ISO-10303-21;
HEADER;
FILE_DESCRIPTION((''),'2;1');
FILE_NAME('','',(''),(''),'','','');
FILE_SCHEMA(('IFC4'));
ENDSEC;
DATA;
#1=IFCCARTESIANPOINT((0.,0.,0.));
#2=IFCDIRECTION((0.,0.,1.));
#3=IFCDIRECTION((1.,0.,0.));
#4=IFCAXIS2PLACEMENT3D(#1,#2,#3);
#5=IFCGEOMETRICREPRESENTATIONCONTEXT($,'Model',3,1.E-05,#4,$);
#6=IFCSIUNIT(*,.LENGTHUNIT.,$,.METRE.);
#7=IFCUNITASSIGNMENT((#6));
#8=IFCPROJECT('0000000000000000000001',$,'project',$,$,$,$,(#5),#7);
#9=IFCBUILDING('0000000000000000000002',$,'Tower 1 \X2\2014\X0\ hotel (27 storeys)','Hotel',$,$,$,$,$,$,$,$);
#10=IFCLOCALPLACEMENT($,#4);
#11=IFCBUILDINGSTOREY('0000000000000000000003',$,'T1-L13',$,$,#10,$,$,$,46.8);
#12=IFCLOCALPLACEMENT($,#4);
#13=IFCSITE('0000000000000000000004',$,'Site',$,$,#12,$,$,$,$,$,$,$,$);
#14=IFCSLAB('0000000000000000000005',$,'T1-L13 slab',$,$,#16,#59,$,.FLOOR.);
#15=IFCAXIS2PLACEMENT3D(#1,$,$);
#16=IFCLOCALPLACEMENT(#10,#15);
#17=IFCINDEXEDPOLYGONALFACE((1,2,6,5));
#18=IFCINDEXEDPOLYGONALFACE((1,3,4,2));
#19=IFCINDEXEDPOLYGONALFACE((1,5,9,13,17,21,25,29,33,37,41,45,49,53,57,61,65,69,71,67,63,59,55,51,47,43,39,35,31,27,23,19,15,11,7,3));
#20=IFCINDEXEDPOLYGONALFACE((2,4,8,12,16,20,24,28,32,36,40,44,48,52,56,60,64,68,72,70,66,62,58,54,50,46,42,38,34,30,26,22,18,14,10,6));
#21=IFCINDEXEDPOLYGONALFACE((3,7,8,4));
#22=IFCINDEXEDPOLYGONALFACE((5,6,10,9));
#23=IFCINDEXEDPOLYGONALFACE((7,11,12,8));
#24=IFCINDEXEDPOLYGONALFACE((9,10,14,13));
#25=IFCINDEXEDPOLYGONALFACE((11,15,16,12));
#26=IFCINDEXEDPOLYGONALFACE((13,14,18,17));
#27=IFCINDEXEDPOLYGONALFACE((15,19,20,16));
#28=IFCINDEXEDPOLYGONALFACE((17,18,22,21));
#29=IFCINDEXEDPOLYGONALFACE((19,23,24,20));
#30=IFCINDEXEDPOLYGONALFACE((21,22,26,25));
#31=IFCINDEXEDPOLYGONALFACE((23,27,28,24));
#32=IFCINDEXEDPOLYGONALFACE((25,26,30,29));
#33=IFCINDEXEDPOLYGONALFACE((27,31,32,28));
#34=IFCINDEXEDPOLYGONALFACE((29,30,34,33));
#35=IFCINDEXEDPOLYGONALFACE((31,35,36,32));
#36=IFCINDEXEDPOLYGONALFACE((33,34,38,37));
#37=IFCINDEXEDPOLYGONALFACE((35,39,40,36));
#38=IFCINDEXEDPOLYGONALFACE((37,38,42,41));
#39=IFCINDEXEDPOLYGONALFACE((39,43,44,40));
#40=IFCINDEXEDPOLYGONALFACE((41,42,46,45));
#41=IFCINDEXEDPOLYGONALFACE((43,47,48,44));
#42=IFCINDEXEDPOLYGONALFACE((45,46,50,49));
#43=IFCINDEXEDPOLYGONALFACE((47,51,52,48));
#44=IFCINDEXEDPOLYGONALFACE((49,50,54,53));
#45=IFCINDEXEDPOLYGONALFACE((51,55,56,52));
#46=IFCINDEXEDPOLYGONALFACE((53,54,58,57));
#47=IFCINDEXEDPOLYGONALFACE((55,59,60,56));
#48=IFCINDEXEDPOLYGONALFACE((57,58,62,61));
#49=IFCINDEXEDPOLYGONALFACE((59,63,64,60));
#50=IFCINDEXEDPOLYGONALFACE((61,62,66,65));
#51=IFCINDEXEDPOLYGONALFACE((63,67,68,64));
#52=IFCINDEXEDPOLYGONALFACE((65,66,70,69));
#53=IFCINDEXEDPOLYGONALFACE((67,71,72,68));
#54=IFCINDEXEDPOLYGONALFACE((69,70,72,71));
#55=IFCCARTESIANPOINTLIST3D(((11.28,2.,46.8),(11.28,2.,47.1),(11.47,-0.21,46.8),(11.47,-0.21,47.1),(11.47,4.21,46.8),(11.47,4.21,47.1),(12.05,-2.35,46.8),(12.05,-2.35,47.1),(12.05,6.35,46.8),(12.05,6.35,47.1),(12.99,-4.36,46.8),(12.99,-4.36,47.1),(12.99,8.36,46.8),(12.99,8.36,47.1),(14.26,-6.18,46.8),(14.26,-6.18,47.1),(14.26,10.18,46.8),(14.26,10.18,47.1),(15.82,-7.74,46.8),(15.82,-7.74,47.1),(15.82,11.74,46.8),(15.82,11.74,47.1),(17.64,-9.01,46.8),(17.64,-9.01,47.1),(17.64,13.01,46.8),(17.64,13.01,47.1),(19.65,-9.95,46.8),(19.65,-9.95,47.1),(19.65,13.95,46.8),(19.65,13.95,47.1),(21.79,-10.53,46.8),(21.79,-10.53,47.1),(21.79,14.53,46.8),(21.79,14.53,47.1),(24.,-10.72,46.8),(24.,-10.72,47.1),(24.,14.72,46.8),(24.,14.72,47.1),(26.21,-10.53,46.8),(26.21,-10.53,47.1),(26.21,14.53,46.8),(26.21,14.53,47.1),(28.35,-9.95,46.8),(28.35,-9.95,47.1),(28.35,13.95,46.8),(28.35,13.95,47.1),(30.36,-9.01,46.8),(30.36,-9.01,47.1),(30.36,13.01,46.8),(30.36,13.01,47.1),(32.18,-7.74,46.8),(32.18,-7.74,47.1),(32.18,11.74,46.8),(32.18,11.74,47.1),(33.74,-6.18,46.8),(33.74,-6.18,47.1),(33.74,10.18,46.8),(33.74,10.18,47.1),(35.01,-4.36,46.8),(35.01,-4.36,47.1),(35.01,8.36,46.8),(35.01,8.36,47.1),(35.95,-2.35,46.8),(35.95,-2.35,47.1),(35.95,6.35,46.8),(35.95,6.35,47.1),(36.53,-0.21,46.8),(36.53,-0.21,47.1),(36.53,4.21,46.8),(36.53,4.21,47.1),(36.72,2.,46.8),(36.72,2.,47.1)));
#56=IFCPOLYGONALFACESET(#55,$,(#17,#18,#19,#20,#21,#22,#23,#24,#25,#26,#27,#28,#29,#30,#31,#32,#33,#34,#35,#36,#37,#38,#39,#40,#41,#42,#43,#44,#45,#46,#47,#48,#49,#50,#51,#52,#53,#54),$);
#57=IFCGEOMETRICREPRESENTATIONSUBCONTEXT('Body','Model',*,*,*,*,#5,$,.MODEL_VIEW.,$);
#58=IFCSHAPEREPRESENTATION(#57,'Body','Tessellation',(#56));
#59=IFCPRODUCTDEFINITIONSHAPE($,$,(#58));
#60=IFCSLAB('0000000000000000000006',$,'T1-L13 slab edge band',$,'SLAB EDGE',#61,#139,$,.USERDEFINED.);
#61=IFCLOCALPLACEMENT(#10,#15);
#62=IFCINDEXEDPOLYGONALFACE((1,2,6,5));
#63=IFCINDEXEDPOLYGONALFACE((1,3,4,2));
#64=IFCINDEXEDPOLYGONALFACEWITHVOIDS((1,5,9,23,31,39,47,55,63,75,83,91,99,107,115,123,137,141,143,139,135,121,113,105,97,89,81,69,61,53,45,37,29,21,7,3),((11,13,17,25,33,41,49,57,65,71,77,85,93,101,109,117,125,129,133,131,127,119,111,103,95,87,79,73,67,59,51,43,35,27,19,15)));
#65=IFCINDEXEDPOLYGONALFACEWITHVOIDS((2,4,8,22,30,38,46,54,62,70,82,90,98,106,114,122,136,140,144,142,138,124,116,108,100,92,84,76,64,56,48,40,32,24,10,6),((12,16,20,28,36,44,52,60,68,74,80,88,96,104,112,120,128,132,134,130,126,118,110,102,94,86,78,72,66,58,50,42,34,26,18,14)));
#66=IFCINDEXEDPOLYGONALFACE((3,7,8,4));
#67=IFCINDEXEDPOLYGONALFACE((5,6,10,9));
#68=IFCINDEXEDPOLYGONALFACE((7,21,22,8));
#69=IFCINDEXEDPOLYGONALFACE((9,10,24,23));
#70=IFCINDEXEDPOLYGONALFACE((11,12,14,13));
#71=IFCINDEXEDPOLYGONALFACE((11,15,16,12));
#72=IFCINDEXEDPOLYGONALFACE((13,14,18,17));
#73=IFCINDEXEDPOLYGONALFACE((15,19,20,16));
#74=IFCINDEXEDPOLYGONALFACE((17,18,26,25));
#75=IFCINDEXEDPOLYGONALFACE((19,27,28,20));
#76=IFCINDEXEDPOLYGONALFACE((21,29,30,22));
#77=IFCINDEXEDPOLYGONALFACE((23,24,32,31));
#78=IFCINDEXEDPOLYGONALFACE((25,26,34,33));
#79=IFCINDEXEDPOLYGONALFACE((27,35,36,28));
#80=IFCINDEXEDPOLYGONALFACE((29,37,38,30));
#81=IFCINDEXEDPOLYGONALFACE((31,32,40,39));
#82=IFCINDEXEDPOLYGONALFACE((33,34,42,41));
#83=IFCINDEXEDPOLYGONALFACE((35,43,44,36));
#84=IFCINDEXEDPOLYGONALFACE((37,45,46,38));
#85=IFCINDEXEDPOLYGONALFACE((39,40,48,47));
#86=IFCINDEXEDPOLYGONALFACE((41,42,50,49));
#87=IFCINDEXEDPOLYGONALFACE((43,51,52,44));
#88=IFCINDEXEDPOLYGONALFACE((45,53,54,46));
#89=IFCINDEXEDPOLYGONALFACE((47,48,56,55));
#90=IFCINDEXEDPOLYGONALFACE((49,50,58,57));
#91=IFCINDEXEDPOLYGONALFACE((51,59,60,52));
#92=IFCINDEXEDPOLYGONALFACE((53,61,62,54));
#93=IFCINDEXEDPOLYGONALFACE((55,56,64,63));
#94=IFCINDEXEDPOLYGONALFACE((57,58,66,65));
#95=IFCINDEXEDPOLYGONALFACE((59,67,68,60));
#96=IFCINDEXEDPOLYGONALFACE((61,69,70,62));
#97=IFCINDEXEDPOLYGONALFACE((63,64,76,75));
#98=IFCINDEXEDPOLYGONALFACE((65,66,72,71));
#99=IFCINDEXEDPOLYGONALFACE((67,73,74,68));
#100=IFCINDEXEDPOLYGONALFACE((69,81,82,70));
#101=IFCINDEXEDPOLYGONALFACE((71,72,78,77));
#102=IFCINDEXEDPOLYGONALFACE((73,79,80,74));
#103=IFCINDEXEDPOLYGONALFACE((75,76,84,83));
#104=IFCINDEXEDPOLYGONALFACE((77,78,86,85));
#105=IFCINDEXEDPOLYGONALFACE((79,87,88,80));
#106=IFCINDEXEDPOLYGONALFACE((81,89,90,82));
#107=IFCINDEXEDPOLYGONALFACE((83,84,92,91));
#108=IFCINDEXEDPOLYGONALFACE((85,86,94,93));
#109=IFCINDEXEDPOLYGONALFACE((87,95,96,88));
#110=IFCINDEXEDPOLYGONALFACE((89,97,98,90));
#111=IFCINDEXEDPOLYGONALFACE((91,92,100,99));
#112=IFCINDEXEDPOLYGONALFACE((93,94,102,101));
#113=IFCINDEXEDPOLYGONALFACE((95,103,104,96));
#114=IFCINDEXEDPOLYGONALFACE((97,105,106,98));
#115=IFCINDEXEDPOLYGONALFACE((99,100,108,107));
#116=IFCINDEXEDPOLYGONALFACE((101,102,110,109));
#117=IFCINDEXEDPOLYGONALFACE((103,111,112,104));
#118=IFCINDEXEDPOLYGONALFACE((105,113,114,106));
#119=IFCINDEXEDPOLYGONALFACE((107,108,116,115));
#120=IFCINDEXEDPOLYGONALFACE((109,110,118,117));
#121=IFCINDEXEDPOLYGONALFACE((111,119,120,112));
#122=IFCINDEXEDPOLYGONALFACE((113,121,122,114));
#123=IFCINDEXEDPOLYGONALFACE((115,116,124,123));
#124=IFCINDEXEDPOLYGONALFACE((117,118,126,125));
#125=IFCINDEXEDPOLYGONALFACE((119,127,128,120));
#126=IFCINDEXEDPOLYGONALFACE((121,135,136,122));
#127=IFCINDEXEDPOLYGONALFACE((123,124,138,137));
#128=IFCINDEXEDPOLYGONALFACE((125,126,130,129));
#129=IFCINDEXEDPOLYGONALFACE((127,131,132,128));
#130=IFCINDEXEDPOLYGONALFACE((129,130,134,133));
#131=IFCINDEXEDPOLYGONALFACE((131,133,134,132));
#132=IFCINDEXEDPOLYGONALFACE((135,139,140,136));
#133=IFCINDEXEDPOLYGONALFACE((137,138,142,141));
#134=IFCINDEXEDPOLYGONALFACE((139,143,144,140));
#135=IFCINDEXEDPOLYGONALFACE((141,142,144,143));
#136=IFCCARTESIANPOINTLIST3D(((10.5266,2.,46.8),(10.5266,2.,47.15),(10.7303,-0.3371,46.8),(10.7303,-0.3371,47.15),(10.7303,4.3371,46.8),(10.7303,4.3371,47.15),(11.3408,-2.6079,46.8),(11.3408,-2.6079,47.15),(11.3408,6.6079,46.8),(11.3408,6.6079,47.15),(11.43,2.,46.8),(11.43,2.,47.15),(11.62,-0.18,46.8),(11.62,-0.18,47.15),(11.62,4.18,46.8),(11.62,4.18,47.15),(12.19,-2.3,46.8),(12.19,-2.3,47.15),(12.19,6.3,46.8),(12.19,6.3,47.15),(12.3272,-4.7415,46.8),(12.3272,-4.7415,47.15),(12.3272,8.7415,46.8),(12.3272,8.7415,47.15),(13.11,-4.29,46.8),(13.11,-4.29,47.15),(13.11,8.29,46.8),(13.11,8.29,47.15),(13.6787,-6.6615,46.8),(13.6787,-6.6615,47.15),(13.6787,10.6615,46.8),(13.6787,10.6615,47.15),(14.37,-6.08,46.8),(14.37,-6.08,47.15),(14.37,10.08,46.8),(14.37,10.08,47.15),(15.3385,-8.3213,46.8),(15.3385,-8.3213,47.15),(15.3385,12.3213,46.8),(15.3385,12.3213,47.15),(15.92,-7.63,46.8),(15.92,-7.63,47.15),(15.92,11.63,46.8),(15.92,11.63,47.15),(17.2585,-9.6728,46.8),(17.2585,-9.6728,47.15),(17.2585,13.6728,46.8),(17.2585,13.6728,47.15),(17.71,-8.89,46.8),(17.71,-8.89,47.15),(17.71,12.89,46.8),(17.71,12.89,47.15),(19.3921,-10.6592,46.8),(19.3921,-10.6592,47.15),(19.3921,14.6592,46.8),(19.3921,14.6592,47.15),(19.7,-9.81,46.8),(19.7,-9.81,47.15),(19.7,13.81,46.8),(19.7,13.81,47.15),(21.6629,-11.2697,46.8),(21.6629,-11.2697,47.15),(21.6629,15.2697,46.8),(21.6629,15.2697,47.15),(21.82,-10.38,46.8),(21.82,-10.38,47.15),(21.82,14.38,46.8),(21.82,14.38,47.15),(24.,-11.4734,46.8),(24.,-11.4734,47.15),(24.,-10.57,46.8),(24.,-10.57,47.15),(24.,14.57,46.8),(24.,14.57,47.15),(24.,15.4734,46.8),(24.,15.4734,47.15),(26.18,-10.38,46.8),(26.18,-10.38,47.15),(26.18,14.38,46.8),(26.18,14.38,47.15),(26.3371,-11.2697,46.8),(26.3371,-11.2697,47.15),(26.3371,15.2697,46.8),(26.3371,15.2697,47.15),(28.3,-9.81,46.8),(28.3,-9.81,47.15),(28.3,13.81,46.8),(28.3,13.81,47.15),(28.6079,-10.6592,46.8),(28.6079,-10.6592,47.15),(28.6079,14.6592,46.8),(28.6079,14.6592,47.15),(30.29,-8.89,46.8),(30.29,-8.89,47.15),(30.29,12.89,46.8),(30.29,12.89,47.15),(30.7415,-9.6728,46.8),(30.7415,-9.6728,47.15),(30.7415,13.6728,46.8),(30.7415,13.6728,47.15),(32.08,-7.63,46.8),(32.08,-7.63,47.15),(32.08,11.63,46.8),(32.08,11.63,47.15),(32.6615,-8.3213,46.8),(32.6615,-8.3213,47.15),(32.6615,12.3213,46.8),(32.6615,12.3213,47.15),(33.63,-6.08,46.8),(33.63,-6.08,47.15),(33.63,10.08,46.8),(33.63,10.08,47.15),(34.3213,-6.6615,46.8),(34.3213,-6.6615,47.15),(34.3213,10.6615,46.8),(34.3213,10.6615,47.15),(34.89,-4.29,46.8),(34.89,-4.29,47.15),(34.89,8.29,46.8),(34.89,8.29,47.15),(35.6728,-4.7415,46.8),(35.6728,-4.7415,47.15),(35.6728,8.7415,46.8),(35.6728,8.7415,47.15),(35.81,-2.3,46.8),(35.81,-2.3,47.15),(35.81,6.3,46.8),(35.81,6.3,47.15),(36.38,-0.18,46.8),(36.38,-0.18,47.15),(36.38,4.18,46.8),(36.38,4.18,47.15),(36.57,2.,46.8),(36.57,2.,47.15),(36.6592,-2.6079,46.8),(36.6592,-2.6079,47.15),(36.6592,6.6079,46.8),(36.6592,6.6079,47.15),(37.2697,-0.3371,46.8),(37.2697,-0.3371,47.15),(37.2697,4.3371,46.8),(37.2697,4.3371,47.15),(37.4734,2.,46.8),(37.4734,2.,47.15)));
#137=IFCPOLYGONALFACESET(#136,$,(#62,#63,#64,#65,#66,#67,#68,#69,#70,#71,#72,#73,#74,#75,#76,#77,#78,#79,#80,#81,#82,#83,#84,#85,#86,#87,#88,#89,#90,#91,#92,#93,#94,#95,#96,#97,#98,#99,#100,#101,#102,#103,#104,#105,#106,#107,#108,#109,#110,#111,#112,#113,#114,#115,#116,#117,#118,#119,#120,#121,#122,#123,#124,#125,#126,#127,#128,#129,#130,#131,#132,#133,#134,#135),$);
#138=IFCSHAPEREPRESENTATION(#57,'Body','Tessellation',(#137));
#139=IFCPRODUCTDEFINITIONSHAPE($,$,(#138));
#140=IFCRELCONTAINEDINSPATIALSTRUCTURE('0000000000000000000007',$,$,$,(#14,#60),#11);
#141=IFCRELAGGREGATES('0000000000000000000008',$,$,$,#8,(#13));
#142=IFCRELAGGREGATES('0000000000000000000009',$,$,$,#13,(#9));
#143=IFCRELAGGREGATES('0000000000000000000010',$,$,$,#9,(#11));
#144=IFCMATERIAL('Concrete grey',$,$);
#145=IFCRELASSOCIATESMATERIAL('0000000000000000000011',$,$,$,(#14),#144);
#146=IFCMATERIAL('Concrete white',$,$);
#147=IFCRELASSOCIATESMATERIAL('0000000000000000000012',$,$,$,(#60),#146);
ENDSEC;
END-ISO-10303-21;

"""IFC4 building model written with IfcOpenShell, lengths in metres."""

from ifc_helpers import new_model, si_unit, frame, origin_with_axes, place, context, subcontext, project, spatial, polyline, outline, extrude, material, element, save


model = new_model("IFC4")

# Units and contexts
model_context = context("Model", 3, precision=1e-05, world=origin_with_axes())
body_context = subcontext(model_context, "Body", "Model", "MODEL_VIEW")
ifc_project = project(units=[si_unit("LENGTHUNIT", "METRE")], contexts=[model_context])

# Site, building, storey
site_placement = place(None, origin_with_axes())
site = spatial("IfcSite", under=ifc_project, at=site_placement, Name="Site")
building = spatial("IfcBuilding", under=site, Name="Tower 1 — hotel (27 storeys)", Description="Hotel")
storey_placement = place(None, origin_with_axes())
storey = spatial("IfcBuildingStorey", under=building, at=storey_placement, Name="T1-L13", Elevation=46.8)

# Slab
ifc_material_1 = material(Name="Concrete grey")
slab_1_placement = place(storey_placement, origin_with_axes())
element("IfcSlab", 1, at=slab_1_placement, inside=storey, material=ifc_material_1, Name="T1-L13 slab", PredefinedType="FLOOR", context=body_context, shape_type="SweptSolid", body=[
    extrude(outline(polyline([(36.53, -0.21), (36.72, 2.0), (36.53, 4.21), (35.95, 6.35), (35.01, 8.36), (33.74, 10.18), (32.18, 11.74), (30.36, 13.01), (28.35, 13.95), (26.21, 14.53), (24.0, 14.72), (21.79, 14.53), (19.65, 13.95), (17.64, 13.01), (15.82, 11.74), (14.26, 10.18), (12.99, 8.36), (12.05, 6.35), (11.47, 4.21), (11.28, 2.0), (11.47, -0.21), (12.05, -2.35), (12.99, -4.36), (14.26, -6.18), (15.82, -7.74), (17.64, -9.01), (19.65, -9.95), (21.79, -10.53), (24.0, -10.72), (26.21, -10.53), (28.35, -9.95), (30.36, -9.01), (32.18, -7.74), (33.74, -6.18), (35.01, -4.36), (35.95, -2.35), (36.53, -0.21)])), frame((0.0, 0.0, 46.8), z_axis=(0.0, 0.0, 1.0), x_axis=(1.0, 0.0, 0.0)), (0.0, 0.0, 1.0), 0.3),
])

# Slab
ifc_material_2 = material(Name="Concrete white")
slab_2_placement = place(storey_placement, origin_with_axes())
element("IfcSlab", 2, at=slab_2_placement, inside=storey, material=ifc_material_2, Name="T1-L13 slab edge band", ObjectType="SLAB EDGE", PredefinedType="USERDEFINED", context=body_context, shape_type="SweptSolid", body=[
    extrude(outline(polyline([(37.4734, 2.0), (37.2697, 4.3371), (36.6592, 6.6079), (35.6728, 8.7415), (34.3213, 10.6615), (32.6615, 12.3213), (30.7415, 13.6728), (28.6079, 14.6592), (26.3371, 15.2697), (24.0, 15.4734), (21.6629, 15.2697), (19.3921, 14.6592), (17.2585, 13.6728), (15.3385, 12.3213), (13.6787, 10.6615), (12.3272, 8.7415), (11.3408, 6.6079), (10.7303, 4.3371), (10.5266, 2.0), (10.7303, -0.3371), (11.3408, -2.6079), (12.3272, -4.7415), (13.6787, -6.6615), (15.3385, -8.3213), (17.2585, -9.6728), (19.3921, -10.6592), (21.6629, -11.2697), (24.0, -11.4734), (26.3371, -11.2697), (28.6079, -10.6592), (30.7415, -9.6728), (32.6615, -8.3213), (34.3213, -6.6615), (35.6728, -4.7415), (36.6592, -2.6079), (37.2697, -0.3371), (37.4734, 2.0)]), holes=[polyline([(36.57, 2.0), (36.38, 4.18), (35.81, 6.3), (34.89, 8.29), (33.63, 10.08), (32.08, 11.63), (30.29, 12.89), (28.3, 13.81), (26.18, 14.38), (24.0, 14.57), (21.82, 14.38), (19.7, 13.81), (17.71, 12.89), (15.92, 11.63), (14.37, 10.08), (13.11, 8.29), (12.19, 6.3), (11.62, 4.18), (11.43, 2.0), (11.62, -0.18), (12.19, -2.3), (13.11, -4.29), (14.37, -6.08), (15.92, -7.63), (17.71, -8.89), (19.7, -9.81), (21.82, -10.38), (24.0, -10.57), (26.18, -10.38), (28.3, -9.81), (30.29, -8.89), (32.08, -7.63), (33.63, -6.08), (34.89, -4.29), (35.81, -2.3), (36.38, -0.18), (36.57, 2.0)])]), frame((0.0, 0.0, 46.8), z_axis=(0.0, 0.0, 1.0), x_axis=(1.0, 0.0, 0.0)), (0.0, 0.0, 1.0), 0.35),
])

save(model, "model.ifc")
